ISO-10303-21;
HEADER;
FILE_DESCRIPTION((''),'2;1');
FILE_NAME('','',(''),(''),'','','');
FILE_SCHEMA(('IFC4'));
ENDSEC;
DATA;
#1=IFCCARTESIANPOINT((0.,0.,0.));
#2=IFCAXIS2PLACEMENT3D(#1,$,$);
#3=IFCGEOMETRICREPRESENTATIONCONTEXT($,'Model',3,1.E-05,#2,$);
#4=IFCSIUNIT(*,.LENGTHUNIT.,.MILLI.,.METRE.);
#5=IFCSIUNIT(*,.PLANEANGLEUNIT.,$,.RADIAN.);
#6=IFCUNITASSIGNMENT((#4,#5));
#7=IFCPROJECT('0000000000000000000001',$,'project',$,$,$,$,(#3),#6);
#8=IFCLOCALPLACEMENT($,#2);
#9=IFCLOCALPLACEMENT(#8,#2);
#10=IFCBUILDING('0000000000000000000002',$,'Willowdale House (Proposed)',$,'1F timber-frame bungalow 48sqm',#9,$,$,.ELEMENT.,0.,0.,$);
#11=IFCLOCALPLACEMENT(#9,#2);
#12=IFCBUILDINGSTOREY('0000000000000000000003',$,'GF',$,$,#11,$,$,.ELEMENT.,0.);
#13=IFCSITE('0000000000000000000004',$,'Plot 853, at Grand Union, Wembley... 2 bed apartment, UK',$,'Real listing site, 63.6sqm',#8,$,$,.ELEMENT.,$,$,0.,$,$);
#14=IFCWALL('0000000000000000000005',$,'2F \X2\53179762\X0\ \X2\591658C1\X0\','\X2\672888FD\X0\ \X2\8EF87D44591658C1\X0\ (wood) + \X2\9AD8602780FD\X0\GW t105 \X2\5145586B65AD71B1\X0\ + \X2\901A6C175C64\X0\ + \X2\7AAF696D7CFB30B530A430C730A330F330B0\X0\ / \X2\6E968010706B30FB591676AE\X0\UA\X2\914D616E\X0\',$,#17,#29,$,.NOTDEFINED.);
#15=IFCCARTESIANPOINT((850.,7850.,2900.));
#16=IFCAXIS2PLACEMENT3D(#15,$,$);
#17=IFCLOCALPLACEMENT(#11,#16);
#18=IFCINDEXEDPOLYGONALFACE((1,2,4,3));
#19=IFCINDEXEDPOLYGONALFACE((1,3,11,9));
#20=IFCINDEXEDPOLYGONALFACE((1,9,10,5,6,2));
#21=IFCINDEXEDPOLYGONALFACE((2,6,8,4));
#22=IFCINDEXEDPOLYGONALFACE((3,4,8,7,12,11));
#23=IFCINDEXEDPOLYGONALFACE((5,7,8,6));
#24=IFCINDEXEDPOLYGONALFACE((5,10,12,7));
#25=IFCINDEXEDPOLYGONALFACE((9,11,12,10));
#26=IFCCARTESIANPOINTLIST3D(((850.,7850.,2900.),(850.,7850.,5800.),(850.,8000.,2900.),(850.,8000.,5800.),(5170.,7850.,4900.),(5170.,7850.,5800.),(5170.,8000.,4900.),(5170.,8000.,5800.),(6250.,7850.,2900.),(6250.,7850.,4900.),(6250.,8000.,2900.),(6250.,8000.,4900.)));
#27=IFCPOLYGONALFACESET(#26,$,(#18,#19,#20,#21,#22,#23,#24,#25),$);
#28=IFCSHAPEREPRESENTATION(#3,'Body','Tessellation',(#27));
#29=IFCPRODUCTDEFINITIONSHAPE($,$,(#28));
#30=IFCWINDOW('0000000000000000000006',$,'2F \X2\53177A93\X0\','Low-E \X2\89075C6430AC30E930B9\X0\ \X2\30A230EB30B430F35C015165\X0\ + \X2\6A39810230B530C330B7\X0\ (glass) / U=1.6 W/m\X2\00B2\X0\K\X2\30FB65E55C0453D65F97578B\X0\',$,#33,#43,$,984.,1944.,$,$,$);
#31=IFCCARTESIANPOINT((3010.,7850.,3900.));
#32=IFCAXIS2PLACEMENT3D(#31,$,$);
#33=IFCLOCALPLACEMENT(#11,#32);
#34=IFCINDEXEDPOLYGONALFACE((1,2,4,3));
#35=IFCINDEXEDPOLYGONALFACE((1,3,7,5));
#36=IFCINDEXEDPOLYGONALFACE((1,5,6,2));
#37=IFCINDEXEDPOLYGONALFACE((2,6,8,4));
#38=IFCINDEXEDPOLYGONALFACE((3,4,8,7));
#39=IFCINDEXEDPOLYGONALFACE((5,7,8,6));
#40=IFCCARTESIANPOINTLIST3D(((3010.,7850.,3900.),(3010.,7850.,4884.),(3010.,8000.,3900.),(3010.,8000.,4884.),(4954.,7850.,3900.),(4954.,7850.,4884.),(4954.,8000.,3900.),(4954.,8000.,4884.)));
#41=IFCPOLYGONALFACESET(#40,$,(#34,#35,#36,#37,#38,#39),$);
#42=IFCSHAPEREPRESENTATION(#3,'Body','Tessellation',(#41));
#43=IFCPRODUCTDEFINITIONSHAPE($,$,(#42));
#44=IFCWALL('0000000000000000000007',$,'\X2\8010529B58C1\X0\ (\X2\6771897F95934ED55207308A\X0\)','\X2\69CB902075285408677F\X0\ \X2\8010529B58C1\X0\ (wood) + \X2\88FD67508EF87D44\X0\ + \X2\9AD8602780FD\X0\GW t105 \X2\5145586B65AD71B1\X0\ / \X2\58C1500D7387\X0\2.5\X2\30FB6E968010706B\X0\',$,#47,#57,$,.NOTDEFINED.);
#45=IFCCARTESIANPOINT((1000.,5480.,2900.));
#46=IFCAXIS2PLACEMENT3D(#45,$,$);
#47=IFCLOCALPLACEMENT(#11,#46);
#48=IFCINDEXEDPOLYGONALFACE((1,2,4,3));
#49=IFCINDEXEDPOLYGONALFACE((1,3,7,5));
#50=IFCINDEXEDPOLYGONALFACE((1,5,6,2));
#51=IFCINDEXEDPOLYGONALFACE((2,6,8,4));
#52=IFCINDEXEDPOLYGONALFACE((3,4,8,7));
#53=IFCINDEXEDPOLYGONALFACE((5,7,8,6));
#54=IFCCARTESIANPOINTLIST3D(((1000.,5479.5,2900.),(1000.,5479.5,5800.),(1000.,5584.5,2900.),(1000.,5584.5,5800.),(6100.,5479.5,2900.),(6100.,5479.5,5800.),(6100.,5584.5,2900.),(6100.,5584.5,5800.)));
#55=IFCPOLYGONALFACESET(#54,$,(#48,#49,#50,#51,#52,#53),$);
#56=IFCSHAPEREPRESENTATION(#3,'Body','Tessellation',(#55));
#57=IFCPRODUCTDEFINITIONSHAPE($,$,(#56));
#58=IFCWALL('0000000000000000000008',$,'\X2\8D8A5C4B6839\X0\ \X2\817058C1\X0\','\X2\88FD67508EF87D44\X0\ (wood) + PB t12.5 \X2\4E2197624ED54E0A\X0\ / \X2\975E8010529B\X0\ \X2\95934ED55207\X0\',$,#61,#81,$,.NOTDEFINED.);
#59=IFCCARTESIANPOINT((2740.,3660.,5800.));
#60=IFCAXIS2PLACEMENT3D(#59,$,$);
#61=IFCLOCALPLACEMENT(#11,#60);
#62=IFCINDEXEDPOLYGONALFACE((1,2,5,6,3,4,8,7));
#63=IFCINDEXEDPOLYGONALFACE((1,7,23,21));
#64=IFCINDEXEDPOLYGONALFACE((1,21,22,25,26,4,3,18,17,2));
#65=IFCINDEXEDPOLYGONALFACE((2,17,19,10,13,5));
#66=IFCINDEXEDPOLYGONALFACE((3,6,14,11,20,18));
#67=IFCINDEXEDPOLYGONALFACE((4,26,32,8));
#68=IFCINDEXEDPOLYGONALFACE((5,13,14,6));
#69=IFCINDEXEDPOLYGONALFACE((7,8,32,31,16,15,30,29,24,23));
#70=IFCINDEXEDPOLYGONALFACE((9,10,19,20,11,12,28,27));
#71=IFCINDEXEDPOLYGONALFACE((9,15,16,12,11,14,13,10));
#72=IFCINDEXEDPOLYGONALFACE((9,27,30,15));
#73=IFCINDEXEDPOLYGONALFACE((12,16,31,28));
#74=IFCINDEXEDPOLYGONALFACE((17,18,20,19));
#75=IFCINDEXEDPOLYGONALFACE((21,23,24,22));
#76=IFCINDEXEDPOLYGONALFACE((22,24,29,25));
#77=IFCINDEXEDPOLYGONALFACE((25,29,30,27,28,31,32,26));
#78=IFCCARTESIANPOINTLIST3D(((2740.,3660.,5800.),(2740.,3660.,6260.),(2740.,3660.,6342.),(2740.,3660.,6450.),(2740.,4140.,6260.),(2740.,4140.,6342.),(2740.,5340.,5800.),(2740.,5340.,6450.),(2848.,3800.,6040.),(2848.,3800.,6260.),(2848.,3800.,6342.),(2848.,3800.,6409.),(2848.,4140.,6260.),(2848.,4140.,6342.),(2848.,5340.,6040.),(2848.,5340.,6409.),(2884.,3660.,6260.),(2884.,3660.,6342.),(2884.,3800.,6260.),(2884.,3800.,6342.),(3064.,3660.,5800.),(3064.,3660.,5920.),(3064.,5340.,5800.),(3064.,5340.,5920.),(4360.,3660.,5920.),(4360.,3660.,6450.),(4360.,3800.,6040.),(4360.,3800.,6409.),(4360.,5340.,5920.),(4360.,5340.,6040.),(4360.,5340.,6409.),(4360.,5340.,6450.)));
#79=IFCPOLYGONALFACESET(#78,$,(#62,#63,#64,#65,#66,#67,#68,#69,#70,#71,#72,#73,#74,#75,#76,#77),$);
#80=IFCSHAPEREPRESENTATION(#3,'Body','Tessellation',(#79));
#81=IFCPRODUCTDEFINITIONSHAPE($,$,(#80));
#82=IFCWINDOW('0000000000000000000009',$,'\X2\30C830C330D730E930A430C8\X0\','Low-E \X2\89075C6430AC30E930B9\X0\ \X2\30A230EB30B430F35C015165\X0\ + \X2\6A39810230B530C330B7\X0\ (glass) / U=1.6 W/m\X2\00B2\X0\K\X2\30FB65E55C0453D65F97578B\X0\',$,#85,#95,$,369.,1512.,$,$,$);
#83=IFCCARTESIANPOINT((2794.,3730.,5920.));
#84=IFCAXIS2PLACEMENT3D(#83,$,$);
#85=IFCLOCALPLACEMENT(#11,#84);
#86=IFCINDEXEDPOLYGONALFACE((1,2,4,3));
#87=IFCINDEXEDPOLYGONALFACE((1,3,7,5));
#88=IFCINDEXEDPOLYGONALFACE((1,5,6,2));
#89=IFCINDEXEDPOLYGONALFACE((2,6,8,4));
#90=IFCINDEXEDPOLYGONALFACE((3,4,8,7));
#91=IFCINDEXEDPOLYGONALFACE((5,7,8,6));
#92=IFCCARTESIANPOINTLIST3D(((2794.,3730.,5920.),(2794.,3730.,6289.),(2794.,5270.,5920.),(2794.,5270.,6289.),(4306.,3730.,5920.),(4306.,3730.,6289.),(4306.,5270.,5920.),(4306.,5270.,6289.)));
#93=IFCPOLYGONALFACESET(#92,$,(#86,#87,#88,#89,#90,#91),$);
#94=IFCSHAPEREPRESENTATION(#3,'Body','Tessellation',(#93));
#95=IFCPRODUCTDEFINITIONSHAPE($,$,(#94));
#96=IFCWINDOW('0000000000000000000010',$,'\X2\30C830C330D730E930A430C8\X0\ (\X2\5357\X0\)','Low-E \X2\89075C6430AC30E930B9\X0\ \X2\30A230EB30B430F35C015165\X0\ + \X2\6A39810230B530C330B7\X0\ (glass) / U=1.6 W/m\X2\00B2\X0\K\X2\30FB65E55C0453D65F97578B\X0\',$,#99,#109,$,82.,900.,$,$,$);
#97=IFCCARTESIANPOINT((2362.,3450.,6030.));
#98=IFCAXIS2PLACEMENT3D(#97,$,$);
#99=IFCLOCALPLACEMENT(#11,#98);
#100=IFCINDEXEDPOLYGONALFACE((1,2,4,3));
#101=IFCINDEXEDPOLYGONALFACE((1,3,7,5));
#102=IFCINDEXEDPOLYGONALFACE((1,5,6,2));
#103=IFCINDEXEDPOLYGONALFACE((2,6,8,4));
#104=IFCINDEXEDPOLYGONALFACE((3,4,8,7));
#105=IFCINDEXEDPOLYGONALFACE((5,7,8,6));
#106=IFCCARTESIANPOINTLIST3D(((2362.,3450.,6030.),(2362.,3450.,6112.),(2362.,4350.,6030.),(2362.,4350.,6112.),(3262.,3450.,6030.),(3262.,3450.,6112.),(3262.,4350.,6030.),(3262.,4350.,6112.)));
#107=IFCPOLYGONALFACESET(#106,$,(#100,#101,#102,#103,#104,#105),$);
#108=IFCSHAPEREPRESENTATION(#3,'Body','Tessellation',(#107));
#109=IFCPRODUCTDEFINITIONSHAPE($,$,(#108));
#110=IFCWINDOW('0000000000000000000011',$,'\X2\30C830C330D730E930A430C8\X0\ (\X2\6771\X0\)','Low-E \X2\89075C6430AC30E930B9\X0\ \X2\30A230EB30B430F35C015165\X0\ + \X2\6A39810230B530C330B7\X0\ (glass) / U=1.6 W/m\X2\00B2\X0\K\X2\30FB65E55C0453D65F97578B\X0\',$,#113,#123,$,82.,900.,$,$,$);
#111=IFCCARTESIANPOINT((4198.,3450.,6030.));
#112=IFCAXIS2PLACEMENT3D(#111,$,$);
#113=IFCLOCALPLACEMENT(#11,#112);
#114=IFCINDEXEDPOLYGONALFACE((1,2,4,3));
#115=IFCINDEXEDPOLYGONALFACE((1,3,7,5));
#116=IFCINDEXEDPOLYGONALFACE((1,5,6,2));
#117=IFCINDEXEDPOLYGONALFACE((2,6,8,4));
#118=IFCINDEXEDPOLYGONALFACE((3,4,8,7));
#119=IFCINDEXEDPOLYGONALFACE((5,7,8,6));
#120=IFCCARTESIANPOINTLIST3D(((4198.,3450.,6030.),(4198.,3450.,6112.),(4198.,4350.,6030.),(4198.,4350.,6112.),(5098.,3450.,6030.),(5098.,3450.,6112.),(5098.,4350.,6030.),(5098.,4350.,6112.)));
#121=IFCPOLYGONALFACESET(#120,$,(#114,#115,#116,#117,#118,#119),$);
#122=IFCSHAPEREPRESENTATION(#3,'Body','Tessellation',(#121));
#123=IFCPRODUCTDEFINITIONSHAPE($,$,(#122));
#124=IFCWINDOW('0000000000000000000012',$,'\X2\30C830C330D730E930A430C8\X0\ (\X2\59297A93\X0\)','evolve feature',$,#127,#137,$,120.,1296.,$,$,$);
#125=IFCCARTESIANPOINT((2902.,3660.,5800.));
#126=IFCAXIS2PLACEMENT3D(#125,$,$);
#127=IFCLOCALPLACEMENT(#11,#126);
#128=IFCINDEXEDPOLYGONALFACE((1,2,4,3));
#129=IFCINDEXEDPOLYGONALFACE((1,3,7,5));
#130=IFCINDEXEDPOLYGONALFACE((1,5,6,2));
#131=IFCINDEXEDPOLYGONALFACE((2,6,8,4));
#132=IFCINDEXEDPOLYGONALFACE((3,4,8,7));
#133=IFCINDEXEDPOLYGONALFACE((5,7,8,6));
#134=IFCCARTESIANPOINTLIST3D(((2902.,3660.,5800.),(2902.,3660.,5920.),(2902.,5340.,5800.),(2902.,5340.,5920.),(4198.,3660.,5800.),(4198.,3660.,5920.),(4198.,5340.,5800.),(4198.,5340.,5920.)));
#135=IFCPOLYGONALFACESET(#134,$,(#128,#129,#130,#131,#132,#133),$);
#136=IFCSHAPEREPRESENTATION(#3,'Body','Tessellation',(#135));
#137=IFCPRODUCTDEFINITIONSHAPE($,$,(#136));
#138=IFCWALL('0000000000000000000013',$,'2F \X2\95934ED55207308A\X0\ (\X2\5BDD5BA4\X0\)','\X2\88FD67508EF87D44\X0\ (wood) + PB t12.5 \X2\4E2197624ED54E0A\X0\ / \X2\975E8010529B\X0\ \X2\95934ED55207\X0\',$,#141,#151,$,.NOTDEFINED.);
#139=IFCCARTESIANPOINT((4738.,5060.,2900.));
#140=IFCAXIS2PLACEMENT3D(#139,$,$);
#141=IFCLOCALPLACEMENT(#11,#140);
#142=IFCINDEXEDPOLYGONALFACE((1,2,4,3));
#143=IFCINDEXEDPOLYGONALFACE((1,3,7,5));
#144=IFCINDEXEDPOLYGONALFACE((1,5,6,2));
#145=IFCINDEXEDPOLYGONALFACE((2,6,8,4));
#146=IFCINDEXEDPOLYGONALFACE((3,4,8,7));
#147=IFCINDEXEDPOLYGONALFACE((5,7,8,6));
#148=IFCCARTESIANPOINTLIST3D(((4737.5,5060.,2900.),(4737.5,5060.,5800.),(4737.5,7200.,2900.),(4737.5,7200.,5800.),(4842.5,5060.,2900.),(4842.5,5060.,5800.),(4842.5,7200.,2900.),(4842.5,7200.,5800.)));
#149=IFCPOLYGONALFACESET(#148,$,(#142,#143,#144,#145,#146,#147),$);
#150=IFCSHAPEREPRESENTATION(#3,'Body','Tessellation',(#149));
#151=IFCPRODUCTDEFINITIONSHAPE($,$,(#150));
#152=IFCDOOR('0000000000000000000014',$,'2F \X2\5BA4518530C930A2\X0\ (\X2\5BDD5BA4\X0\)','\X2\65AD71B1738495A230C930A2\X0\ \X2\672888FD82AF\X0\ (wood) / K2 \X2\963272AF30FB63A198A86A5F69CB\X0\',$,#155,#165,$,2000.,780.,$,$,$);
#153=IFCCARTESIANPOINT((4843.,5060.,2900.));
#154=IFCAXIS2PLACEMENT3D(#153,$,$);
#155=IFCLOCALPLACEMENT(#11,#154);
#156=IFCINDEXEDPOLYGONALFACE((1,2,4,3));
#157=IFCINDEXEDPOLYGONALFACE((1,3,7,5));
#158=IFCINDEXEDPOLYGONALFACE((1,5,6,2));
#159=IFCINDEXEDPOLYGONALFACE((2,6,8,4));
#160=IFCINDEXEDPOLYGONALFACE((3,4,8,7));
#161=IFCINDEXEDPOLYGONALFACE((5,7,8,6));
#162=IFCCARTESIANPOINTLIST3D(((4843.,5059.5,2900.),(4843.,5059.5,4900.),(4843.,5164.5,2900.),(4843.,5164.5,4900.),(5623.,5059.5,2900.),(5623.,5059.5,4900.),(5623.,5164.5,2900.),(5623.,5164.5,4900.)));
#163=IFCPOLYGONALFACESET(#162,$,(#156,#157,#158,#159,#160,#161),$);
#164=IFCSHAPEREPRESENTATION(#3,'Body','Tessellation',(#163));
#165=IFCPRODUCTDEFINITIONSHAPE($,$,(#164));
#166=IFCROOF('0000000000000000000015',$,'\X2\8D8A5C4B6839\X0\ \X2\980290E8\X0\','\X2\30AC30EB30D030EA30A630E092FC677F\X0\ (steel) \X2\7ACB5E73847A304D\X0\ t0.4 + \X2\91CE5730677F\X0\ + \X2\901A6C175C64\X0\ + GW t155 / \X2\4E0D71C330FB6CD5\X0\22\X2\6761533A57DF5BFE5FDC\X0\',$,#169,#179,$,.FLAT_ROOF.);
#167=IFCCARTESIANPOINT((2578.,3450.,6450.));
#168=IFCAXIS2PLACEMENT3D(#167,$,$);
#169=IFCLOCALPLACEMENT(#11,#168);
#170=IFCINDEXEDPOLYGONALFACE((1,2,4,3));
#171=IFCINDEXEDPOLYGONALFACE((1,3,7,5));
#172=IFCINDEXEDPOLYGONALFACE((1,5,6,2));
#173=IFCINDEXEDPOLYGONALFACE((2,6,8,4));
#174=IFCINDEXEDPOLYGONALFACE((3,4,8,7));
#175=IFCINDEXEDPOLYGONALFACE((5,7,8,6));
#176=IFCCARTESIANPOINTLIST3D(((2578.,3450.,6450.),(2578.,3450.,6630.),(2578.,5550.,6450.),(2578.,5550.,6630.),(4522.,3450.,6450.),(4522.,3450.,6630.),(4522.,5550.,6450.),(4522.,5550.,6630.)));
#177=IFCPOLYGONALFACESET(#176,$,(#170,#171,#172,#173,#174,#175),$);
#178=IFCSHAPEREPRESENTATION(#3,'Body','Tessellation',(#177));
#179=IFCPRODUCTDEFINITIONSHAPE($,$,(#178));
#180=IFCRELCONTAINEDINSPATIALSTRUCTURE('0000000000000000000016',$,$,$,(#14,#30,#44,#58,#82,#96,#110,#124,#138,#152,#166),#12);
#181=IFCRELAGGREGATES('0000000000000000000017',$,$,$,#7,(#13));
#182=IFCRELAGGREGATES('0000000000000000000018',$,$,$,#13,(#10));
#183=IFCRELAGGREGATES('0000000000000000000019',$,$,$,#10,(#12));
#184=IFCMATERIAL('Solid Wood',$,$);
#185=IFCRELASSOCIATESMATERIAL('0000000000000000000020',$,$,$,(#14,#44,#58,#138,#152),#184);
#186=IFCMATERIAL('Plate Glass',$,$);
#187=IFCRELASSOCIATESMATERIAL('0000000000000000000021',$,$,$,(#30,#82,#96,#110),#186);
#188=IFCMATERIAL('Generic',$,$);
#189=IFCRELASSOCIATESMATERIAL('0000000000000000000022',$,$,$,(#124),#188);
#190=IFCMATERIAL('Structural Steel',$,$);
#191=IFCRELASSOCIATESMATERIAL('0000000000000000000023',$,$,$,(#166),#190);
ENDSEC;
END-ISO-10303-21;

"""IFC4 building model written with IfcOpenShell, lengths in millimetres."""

from ifc_helpers import new_model, si_unit, frame, frame_2d, origin, place, context, project, spatial, rectangle, extrude, material, element, fill, save


model = new_model("IFC4")

# Units and contexts
model_context = context("Model", 3, precision=1e-05, world=origin())
ifc_project = project(units=[si_unit("LENGTHUNIT", "METRE", prefix="MILLI"), si_unit("PLANEANGLEUNIT", "RADIAN")], contexts=[model_context])

# Site, building, storey
site_placement = place(None, origin())
site = spatial("IfcSite", under=ifc_project, at=site_placement, Name="Plot 853, at Grand Union, Wembley... 2 bed apartment, UK", ObjectType="Real listing site, 63.6sqm", CompositionType="ELEMENT", RefElevation=0.0)
building_placement = place(site_placement, origin())
building = spatial("IfcBuilding", under=site, at=building_placement, Name="Willowdale House (Proposed)", ObjectType="1F timber-frame bungalow 48sqm", CompositionType="ELEMENT", ElevationOfRefHeight=0.0, ElevationOfTerrain=0.0)
storey_placement = place(building_placement, origin())
storey = spatial("IfcBuildingStorey", under=building, at=storey_placement, Name="GF", CompositionType="ELEMENT", Elevation=0.0)

# Wall, opening, window
ifc_material_1 = material(Name="Solid Wood")
wall_1_placement = place(storey_placement, frame((850.0, 7850.0, 2900.0)))
wall_1 = element("IfcWall", 1, at=wall_1_placement, inside=storey, material=ifc_material_1, Name="2F 北面 外壁", Description="木製 軸組外壁 (wood) + 高性能GW t105 充填断熱 + 通気層 + 窯業系サイディング / 準耐火・外皮UA配慮", PredefinedType="NOTDEFINED", context=model_context, shape_type="SweptSolid", body=[
    extrude(rectangle(XDim=5400.0, YDim=150.0, at=frame_2d((2700.0, 75.0))), frame((850.0, 7850.0, 2900.0)), (0.0, 0.0, 1.0), 2900.0),
])
opening_1_placement = place(storey_placement, frame((3010.0, 7850.0, 3900.0)))
opening_1 = element("IfcOpeningElement", 2, at=opening_1_placement, cuts=wall_1, PredefinedType="NOTDEFINED", context=model_context, shape_type="SweptSolid", body=[
    extrude(rectangle(XDim=1944.0, YDim=150.0, at=frame_2d((972.0, 75.0))), frame((3010.0, 7850.0, 3900.0)), (0.0, 0.0, 1.0), 984.0),
])
ifc_material_2 = material(Name="Plate Glass")
window_1_placement = place(storey_placement, frame((3010.0, 7850.0, 3900.0)))
window_1 = element("IfcWindow", 3, at=window_1_placement, inside=storey, material=ifc_material_2, Name="2F 北窓", Description="Low-E 複層ガラス アルゴン封入 + 樹脂サッシ (glass) / U=1.6 W/m²K・日射取得型", OverallHeight=984.0, OverallWidth=1944.0, context=model_context, shape_type="SweptSolid", body=[
    extrude(rectangle(XDim=1944.0, YDim=150.0, at=frame_2d((972.0, 75.0))), frame((3010.0, 7850.0, 3900.0)), (0.0, 0.0, 1.0), 984.0),
])
fill(opening_1, window_1)

# Wall
wall_2_placement = place(storey_placement, frame((1000.0, 5480.0, 2900.0)))
element("IfcWall", 4, at=wall_2_placement, inside=storey, material=ifc_material_1, Name="耐力壁 (東西間仕切り)", Description="構造用合板 耐力壁 (wood) + 製材軸組 + 高性能GW t105 充填断熱 / 壁倍率2.5・準耐火", PredefinedType="NOTDEFINED", context=model_context, shape_type="SweptSolid", body=[
    extrude(rectangle(XDim=5100.0, YDim=105.0, at=frame_2d((2550.0, 52.0))), frame((1000.0, 5480.0, 2900.0)), (0.0, 0.0, 1.0), 2900.0),
])

# Wall, openings, windows
wall_3_placement = place(storey_placement, frame((2740.0, 3660.0, 5800.0)))
wall_3 = element("IfcWall", 5, at=wall_3_placement, inside=storey, material=ifc_material_1, Name="越屋根 腰壁", Description="製材軸組 (wood) + PB t12.5 両面仕上 / 非耐力 間仕切", PredefinedType="NOTDEFINED", context=model_context, shape_type="SweptSolid", body=[
    extrude(rectangle(XDim=1620.0, YDim=1680.0, at=frame_2d((810.0, 840.0))), frame((2740.0, 3660.0, 5800.0)), (0.0, 0.0, 1.0), 650.0),
])
opening_2_placement = place(storey_placement, frame((2794.0, 3730.0, 5920.0)))
opening_2 = element("IfcOpeningElement", 6, at=opening_2_placement, cuts=wall_3, PredefinedType="NOTDEFINED", context=model_context, shape_type="SweptSolid", body=[
    extrude(rectangle(XDim=1512.0, YDim=1540.0, at=frame_2d((756.0, 770.0))), frame((2794.0, 3730.0, 5920.0)), (0.0, 0.0, 1.0), 369.0),
])
opening_3_placement = place(storey_placement, frame((2362.0, 3450.0, 6030.0)))
opening_3 = element("IfcOpeningElement", 7, at=opening_3_placement, cuts=wall_3, PredefinedType="NOTDEFINED", context=model_context, shape_type="SweptSolid", body=[
    extrude(rectangle(XDim=900.0, YDim=900.0, at=frame_2d((450.0, 450.0))), frame((2362.0, 3450.0, 6030.0)), (0.0, 0.0, 1.0), 82.0),
])
opening_4_placement = place(storey_placement, frame((4198.0, 3450.0, 6030.0)))
opening_4 = element("IfcOpeningElement", 8, at=opening_4_placement, cuts=wall_3, PredefinedType="NOTDEFINED", context=model_context, shape_type="SweptSolid", body=[
    extrude(rectangle(XDim=900.0, YDim=900.0, at=frame_2d((450.0, 450.0))), frame((4198.0, 3450.0, 6030.0)), (0.0, 0.0, 1.0), 82.0),
])
opening_5_placement = place(storey_placement, frame((2902.0, 3660.0, 5800.0)))
opening_5 = element("IfcOpeningElement", 9, at=opening_5_placement, cuts=wall_3, PredefinedType="NOTDEFINED", context=model_context, shape_type="SweptSolid", body=[
    extrude(rectangle(XDim=1296.0, YDim=1680.0, at=frame_2d((648.0, 840.0))), frame((2902.0, 3660.0, 5800.0)), (0.0, 0.0, 1.0), 120.0),
])
window_2_placement = place(storey_placement, frame((2794.0, 3730.0, 5920.0)))
window_2 = element("IfcWindow", 10, at=window_2_placement, inside=storey, material=ifc_material_2, Name="トップライト", Description="Low-E 複層ガラス アルゴン封入 + 樹脂サッシ (glass) / U=1.6 W/m²K・日射取得型", OverallHeight=369.0, OverallWidth=1512.0, context=model_context, shape_type="SweptSolid", body=[
    extrude(rectangle(XDim=1512.0, YDim=1540.0, at=frame_2d((756.0, 770.0))), frame((2794.0, 3730.0, 5920.0)), (0.0, 0.0, 1.0), 369.0),
])
fill(opening_2, window_2)
window_3_placement = place(storey_placement, frame((2362.0, 3450.0, 6030.0)))
window_3 = element("IfcWindow", 11, at=window_3_placement, inside=storey, material=ifc_material_2, Name="トップライト (南)", Description="Low-E 複層ガラス アルゴン封入 + 樹脂サッシ (glass) / U=1.6 W/m²K・日射取得型", OverallHeight=82.0, OverallWidth=900.0, context=model_context, shape_type="SweptSolid", body=[
    extrude(rectangle(XDim=900.0, YDim=900.0, at=frame_2d((450.0, 450.0))), frame((2362.0, 3450.0, 6030.0)), (0.0, 0.0, 1.0), 82.0),
])
fill(opening_3, window_3)
window_4_placement = place(storey_placement, frame((4198.0, 3450.0, 6030.0)))
window_4 = element("IfcWindow", 12, at=window_4_placement, inside=storey, material=ifc_material_2, Name="トップライト (東)", Description="Low-E 複層ガラス アルゴン封入 + 樹脂サッシ (glass) / U=1.6 W/m²K・日射取得型", OverallHeight=82.0, OverallWidth=900.0, context=model_context, shape_type="SweptSolid", body=[
    extrude(rectangle(XDim=900.0, YDim=900.0, at=frame_2d((450.0, 450.0))), frame((4198.0, 3450.0, 6030.0)), (0.0, 0.0, 1.0), 82.0),
])
fill(opening_4, window_4)
ifc_material_3 = material(Name="Generic")
window_5_placement = place(storey_placement, frame((2902.0, 3660.0, 5800.0)))
window_5 = element("IfcWindow", 13, at=window_5_placement, inside=storey, material=ifc_material_3, Name="トップライト (天窓)", Description="evolve feature", OverallHeight=120.0, OverallWidth=1296.0, context=model_context, shape_type="SweptSolid", body=[
    extrude(rectangle(XDim=1296.0, YDim=1680.0, at=frame_2d((648.0, 840.0))), frame((2902.0, 3660.0, 5800.0)), (0.0, 0.0, 1.0), 120.0),
])
fill(opening_5, window_5)

# Wall
wall_4_placement = place(storey_placement, frame((4738.0, 5060.0, 2900.0)))
element("IfcWall", 14, at=wall_4_placement, inside=storey, material=ifc_material_1, Name="2F 間仕切り (寝室)", Description="製材軸組 (wood) + PB t12.5 両面仕上 / 非耐力 間仕切", PredefinedType="NOTDEFINED", context=model_context, shape_type="SweptSolid", body=[
    extrude(rectangle(XDim=105.0, YDim=2140.0, at=frame_2d((52.0, 1070.0))), frame((4738.0, 5060.0, 2900.0)), (0.0, 0.0, 1.0), 2900.0),
])

# Door
door_placement = place(storey_placement, frame((4843.0, 5060.0, 2900.0)))
element("IfcDoor", 15, at=door_placement, inside=storey, material=ifc_material_1, Name="2F 室内ドア (寝室)", Description="断熱玄関ドア 木製芯 (wood) / K2 防犯・採風機構", OverallHeight=2000.0, OverallWidth=780.0, context=model_context, shape_type="SweptSolid", body=[
    extrude(rectangle(XDim=780.0, YDim=105.0, at=frame_2d((390.0, 52.0))), frame((4843.0, 5060.0, 2900.0)), (0.0, 0.0, 1.0), 2000.0),
])

# Roof
ifc_material_4 = material(Name="Structural Steel")
roof_placement = place(storey_placement, frame((2578.0, 3450.0, 6450.0)))
element("IfcRoof", 16, at=roof_placement, inside=storey, material=ifc_material_4, Name="越屋根 頂部", Description="ガルバリウム鋼板 (steel) 立平葺き t0.4 + 野地板 + 通気層 + GW t155 / 不燃・法22条区域対応", PredefinedType="FLAT_ROOF", context=model_context, shape_type="SweptSolid", body=[
    extrude(rectangle(XDim=1944.0, YDim=2100.0, at=frame_2d((972.0, 1050.0))), frame((2578.0, 3450.0, 6450.0)), (0.0, 0.0, 1.0), 180.0),
])

save(model, "model.ifc")
